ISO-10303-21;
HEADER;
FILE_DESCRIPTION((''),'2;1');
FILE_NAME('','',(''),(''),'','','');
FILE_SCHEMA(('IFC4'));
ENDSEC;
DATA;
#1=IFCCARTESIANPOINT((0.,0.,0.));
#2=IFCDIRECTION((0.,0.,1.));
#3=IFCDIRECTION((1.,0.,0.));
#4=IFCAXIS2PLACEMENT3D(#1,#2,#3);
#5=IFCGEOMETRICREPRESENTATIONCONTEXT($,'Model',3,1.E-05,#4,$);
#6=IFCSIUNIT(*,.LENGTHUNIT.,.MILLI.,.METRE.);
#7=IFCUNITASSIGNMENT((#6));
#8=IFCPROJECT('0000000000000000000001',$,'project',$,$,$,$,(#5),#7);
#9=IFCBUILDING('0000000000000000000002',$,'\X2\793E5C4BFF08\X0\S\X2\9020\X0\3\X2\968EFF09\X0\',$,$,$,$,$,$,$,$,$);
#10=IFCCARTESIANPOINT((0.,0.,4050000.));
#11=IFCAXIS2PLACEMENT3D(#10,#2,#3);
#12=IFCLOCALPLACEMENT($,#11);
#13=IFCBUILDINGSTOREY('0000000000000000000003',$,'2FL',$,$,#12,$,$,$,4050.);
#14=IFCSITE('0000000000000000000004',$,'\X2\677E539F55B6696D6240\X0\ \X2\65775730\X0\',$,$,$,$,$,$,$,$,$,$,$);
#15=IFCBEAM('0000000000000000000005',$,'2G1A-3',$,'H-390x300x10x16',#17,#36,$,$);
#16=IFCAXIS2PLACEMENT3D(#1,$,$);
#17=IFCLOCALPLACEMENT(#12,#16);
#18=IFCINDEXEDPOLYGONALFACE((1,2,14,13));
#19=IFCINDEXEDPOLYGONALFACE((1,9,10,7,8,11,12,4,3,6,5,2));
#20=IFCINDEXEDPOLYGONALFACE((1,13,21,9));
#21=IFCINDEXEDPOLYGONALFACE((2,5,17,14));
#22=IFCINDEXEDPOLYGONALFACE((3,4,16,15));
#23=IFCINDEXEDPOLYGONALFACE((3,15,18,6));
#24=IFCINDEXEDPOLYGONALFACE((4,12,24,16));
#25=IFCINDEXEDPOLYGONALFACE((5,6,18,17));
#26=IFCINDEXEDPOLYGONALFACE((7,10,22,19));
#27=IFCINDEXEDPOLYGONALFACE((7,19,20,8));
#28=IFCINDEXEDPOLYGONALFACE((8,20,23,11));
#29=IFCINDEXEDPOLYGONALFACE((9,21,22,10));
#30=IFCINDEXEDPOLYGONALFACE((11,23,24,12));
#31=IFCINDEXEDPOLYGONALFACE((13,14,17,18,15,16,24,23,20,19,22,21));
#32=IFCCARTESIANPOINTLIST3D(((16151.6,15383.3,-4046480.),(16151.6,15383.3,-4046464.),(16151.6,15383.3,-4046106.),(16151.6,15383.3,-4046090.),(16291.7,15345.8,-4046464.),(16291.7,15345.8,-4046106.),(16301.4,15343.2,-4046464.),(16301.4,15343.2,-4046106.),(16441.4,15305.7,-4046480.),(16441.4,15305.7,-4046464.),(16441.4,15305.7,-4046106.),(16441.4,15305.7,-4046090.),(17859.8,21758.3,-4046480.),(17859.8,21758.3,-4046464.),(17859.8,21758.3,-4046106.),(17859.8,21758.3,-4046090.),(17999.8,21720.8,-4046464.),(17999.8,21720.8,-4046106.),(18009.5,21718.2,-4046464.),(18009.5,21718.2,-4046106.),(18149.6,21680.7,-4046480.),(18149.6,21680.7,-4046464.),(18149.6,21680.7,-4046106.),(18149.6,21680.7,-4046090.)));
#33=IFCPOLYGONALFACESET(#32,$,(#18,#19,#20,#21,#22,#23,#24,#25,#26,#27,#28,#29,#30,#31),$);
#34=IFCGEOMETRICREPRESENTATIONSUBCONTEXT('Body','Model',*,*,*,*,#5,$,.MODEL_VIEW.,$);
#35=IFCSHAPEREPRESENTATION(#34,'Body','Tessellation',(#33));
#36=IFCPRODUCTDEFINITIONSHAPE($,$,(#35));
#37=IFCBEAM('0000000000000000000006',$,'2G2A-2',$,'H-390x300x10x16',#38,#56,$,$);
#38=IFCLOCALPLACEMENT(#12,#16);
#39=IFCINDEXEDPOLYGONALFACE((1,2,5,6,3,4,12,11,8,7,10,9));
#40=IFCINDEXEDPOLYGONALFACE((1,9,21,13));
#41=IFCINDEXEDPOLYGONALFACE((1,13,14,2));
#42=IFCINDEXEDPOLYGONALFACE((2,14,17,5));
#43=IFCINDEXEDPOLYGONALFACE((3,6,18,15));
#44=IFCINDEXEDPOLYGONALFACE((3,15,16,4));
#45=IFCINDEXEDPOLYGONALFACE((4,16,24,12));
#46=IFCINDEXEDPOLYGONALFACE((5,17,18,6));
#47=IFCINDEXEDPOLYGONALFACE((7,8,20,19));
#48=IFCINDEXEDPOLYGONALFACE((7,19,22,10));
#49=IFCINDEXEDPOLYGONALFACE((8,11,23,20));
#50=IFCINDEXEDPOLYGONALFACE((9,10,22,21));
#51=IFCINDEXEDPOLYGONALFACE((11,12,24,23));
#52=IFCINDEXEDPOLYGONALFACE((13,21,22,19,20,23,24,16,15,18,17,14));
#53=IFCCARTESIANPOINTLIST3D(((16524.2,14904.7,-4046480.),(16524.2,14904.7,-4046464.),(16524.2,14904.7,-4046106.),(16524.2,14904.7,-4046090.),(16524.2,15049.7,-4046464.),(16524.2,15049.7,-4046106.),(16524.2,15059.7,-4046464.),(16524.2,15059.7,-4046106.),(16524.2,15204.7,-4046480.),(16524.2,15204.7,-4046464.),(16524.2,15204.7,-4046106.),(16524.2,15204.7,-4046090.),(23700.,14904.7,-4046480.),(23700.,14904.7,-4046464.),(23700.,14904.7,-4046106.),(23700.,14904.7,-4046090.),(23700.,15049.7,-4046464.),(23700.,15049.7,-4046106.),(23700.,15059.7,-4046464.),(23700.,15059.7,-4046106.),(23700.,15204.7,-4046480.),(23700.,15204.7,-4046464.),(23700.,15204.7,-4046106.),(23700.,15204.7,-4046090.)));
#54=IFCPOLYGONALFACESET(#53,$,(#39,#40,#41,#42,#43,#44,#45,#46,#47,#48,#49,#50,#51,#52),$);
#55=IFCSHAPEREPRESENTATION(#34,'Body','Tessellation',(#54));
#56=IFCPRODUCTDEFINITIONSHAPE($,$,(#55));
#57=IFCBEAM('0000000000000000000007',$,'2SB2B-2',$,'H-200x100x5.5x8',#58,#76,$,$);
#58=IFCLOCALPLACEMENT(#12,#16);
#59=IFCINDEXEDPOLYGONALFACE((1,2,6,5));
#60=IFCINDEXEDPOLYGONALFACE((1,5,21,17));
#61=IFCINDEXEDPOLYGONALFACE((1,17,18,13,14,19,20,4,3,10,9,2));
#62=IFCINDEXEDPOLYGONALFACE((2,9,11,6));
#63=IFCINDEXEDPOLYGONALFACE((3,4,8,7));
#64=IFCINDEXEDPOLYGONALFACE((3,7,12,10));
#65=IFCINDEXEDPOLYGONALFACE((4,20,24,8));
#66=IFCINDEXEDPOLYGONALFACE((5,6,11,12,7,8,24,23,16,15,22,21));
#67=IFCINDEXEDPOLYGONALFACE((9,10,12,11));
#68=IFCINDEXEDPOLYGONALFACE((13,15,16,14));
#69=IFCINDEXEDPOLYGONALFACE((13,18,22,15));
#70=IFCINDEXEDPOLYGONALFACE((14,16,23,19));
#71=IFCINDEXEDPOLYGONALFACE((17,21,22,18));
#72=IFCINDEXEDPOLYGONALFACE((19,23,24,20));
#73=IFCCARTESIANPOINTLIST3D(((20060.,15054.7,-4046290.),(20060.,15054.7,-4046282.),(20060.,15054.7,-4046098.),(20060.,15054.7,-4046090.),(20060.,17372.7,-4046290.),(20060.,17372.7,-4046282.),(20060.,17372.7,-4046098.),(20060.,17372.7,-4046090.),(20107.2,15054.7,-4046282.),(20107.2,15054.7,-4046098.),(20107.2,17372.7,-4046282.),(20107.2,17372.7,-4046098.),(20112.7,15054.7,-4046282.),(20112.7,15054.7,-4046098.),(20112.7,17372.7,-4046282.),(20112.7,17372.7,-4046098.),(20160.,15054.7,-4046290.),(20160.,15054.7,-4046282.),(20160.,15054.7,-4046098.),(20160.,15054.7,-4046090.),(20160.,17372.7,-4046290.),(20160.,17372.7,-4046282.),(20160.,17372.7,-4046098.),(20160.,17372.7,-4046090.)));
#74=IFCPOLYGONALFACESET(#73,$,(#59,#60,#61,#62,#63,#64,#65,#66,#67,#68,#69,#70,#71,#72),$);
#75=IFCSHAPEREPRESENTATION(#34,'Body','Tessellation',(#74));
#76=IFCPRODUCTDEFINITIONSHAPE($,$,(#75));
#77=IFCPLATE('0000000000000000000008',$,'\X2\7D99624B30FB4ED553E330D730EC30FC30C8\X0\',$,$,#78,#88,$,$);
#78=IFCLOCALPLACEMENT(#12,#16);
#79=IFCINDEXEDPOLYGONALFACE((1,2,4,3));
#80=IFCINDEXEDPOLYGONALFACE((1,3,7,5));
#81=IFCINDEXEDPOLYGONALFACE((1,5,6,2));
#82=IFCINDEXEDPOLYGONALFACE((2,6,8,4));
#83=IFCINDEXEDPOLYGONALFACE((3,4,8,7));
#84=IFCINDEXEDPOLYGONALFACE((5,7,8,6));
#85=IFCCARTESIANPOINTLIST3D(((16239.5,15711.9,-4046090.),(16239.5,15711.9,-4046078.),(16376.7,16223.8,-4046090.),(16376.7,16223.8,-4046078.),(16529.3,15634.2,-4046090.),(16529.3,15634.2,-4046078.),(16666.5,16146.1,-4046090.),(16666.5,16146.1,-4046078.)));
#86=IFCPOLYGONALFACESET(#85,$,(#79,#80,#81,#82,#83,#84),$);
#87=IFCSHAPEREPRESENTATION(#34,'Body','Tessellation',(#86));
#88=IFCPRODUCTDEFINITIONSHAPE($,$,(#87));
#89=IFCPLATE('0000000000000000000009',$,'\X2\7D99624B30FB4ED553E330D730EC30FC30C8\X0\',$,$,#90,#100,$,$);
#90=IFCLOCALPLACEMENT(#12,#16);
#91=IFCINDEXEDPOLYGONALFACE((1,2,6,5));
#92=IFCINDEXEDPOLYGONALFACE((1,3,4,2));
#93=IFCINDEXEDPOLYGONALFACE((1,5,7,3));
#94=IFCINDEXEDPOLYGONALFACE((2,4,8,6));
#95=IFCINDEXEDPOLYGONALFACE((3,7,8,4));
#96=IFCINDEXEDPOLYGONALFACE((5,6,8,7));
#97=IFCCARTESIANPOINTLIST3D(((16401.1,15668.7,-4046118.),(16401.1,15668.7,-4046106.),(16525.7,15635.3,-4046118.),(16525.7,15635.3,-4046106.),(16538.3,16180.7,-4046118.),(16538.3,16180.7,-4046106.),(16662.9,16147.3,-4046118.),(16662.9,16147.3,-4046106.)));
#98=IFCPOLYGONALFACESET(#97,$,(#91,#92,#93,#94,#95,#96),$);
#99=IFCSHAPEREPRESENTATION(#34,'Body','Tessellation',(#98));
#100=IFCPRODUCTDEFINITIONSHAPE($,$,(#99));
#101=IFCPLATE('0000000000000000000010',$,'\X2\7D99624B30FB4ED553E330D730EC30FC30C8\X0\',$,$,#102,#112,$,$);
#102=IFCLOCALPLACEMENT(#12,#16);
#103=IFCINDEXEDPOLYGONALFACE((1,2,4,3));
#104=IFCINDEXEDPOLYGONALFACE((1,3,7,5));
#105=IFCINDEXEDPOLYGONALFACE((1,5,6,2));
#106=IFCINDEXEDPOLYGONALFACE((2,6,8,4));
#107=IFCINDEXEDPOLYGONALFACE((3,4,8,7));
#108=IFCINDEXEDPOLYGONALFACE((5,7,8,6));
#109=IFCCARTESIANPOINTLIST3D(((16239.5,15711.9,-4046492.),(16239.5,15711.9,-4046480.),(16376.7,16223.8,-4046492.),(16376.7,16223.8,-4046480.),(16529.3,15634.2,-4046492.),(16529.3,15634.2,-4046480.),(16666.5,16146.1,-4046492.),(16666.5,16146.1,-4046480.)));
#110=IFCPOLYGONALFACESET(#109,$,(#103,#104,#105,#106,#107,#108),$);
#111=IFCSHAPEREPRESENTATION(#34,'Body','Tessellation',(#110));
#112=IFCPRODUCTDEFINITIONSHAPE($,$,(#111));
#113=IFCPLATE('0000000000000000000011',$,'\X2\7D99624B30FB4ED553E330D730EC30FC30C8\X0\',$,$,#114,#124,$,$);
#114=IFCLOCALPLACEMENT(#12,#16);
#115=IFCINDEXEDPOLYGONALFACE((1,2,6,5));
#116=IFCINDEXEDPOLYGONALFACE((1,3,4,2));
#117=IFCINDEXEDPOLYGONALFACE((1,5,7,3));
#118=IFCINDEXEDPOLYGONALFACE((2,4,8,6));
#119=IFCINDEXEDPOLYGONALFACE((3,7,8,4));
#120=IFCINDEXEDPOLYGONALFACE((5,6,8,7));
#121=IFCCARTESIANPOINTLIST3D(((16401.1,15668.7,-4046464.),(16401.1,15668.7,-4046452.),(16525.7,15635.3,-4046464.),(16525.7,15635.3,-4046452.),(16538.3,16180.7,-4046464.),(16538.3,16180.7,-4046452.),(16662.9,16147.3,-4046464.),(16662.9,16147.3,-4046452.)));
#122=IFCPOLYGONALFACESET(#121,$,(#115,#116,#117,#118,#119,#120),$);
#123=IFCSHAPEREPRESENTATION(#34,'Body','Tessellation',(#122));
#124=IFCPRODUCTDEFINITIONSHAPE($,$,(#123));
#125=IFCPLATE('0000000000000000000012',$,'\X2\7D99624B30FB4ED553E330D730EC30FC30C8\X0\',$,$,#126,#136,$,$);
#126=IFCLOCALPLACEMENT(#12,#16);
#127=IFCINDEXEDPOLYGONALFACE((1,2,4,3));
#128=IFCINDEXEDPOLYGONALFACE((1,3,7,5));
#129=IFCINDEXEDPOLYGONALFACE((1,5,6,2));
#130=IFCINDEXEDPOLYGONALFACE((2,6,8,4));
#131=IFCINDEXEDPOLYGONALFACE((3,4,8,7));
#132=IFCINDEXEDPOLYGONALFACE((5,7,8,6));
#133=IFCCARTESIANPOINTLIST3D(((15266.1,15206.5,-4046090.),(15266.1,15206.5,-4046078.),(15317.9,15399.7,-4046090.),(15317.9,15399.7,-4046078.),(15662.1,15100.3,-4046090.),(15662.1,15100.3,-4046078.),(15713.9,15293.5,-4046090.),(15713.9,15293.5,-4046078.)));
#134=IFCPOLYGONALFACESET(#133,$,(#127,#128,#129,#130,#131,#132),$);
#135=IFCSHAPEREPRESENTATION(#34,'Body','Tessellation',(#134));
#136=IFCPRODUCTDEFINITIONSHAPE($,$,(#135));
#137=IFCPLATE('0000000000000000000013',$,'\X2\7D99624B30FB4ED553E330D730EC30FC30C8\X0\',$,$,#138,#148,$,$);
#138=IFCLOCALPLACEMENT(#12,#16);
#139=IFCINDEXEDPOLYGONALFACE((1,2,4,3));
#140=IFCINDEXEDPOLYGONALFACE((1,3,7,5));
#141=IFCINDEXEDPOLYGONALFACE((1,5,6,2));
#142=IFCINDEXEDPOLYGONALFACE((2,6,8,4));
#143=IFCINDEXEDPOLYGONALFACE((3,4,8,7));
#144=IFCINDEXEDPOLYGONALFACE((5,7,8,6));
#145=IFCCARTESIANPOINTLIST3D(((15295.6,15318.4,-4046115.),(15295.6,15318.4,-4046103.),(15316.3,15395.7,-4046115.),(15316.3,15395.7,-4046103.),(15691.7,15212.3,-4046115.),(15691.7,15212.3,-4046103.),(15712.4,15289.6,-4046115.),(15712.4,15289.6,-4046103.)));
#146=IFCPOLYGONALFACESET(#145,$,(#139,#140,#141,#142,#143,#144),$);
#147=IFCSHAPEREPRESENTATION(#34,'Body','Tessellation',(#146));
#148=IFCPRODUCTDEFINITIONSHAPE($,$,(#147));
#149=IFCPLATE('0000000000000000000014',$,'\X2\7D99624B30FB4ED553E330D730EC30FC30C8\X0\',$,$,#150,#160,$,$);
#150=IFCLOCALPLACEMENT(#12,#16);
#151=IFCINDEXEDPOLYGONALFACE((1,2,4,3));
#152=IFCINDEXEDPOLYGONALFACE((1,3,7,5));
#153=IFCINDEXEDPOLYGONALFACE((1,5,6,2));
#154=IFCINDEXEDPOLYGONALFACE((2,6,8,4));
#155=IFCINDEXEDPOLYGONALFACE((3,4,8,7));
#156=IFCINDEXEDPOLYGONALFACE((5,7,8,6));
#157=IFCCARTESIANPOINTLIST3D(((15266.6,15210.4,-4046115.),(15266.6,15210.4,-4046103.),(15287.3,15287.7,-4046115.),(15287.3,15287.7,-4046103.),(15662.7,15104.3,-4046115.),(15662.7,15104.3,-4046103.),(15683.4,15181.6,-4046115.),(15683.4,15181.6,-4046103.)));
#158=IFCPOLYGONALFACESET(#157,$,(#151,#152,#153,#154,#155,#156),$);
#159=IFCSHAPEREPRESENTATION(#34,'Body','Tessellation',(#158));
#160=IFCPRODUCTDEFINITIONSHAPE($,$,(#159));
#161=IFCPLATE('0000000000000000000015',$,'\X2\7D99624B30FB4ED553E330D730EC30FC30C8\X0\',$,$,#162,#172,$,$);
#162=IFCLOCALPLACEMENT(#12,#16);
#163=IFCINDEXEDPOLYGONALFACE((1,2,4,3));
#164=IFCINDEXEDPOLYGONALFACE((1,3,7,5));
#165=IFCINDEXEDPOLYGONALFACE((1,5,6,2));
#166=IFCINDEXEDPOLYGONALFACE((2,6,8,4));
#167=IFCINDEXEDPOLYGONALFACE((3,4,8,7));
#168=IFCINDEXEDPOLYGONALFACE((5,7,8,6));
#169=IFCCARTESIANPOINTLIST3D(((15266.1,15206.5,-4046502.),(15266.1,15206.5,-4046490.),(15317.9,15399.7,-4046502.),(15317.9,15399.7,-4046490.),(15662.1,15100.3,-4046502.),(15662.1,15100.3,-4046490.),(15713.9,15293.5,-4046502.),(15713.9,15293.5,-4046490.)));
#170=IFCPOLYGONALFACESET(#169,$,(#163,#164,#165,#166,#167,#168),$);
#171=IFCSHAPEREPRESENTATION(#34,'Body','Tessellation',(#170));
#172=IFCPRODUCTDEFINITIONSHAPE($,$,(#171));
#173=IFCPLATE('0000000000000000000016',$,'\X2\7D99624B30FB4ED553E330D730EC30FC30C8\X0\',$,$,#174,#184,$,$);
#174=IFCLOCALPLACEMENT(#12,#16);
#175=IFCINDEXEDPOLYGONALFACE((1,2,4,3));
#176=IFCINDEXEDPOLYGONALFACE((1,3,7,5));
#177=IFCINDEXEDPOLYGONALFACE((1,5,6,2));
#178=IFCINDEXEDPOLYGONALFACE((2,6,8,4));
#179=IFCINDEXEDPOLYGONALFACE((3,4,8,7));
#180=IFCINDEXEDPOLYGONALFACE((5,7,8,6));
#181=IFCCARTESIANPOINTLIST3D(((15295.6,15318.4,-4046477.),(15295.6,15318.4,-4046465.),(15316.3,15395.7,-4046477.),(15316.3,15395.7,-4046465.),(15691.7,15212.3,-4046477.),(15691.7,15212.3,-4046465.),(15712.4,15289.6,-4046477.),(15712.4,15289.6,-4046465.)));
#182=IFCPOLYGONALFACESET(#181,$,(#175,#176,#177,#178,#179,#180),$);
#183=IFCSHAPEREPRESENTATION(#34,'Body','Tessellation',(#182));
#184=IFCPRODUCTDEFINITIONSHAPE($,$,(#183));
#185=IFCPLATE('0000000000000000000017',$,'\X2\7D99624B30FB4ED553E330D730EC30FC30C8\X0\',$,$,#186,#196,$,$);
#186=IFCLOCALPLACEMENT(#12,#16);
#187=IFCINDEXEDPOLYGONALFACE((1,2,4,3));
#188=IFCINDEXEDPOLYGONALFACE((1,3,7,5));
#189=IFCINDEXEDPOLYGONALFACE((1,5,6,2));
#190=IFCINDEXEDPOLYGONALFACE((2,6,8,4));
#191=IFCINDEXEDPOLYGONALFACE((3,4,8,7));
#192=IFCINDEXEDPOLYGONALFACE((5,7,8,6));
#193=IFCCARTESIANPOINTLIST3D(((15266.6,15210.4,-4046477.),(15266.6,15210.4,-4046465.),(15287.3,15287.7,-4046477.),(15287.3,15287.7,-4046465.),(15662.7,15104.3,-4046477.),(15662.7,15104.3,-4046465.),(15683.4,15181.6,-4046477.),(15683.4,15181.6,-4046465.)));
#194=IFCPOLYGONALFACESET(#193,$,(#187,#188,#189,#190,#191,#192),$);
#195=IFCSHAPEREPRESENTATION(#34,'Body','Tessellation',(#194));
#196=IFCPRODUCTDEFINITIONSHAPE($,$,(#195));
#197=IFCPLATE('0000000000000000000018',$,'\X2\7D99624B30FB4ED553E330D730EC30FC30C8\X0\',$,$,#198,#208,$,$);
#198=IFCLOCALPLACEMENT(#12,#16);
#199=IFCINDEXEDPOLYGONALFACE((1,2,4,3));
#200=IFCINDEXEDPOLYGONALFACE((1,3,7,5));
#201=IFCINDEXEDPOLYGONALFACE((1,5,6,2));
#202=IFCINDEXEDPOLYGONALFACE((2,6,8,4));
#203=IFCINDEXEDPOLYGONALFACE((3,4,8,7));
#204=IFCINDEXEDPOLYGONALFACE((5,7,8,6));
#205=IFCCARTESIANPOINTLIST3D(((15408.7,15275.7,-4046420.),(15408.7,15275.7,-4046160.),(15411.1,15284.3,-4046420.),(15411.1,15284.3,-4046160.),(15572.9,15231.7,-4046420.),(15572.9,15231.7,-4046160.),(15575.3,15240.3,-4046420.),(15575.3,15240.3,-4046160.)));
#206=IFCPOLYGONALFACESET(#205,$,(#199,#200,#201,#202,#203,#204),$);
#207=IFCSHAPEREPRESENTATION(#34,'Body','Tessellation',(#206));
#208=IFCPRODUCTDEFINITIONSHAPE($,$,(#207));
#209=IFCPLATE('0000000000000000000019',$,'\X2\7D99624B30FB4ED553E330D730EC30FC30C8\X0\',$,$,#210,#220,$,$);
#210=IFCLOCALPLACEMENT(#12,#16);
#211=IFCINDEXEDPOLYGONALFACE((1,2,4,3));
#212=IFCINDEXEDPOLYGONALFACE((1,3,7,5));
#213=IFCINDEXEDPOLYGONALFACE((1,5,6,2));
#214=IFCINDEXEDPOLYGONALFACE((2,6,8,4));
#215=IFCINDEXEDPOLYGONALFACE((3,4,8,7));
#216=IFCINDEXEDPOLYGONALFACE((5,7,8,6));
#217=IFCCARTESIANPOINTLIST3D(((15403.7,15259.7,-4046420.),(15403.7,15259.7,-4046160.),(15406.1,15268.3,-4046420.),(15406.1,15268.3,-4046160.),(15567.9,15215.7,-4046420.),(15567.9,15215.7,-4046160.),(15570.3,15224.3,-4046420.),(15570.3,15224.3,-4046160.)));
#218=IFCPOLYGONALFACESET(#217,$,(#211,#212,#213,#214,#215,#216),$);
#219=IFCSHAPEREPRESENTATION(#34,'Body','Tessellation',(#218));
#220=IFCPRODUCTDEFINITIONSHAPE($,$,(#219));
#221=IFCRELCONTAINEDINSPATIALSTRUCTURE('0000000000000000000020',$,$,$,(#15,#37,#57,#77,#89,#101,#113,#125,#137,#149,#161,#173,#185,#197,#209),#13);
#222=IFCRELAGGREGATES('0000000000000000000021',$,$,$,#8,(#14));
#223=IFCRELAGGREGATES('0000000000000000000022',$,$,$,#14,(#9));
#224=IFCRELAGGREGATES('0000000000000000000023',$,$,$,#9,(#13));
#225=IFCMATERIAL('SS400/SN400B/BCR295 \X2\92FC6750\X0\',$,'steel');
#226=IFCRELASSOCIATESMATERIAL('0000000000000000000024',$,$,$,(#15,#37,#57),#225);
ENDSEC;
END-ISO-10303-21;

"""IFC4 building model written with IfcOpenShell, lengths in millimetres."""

from ifc_helpers import new_model, si_unit, frame, origin, origin_with_axes, place, context, subcontext, project, spatial, rectangle, i_section, extrude, material, element, save


model = new_model("IFC4")

# Units and contexts
model_context = context("Model", 3, precision=1e-05, world=origin_with_axes())
body_context = subcontext(model_context, "Body", "Model", "MODEL_VIEW")
ifc_project = project(units=[si_unit("LENGTHUNIT", "METRE", prefix="MILLI")], contexts=[model_context])

# Site, building, storey
site = spatial("IfcSite", under=ifc_project, Name="松原営業所 敷地")
building = spatial("IfcBuilding", under=site, Name="社屋（S造3階）")
storey_placement = place(None, frame((0.0, 0.0, 4050000.0), z_axis=(0.0, 0.0, 1.0), x_axis=(1.0, 0.0, 0.0)))
storey = spatial("IfcBuildingStorey", under=building, at=storey_placement, Name="2FL", Elevation=4050.0)

# Beams
ifc_material = material(Name="SS400/SN400B/BCR295 鋼材", Category="steel")
beam_1_placement = place(storey_placement, frame((16296.5, 15344.5, -4046090.0), z_axis=(0.258815, 0.965927, 0.0), x_axis=(-0.965927, 0.258815, 0.0)))
element("IfcBeam", 1, at=beam_1_placement, inside=storey, material=ifc_material, Name="2G1A-3", ObjectType="H-390x300x10x16", context=body_context, shape_type="SweptSolid", body=[
    extrude(i_section(OverallWidth=300.0, OverallDepth=390.0, WebThickness=10.0, FlangeThickness=16.0), frame((0.0, -195.0, 0.0)), (0.0, 0.0, 1.0), 6599.9),
])
beam_2_placement = place(storey_placement, frame((16524.2, 15054.7, -4046090.0), z_axis=(1.0, 0.0, 0.0), x_axis=(0.0, 1.0, 0.0)))
element("IfcBeam", 2, at=beam_2_placement, inside=storey, material=ifc_material, Name="2G2A-2", ObjectType="H-390x300x10x16", context=body_context, shape_type="SweptSolid", body=[
    extrude(i_section(OverallWidth=300.0, OverallDepth=390.0, WebThickness=10.0, FlangeThickness=16.0), frame((0.0, -195.0, 0.0)), (0.0, 0.0, 1.0), 7175.8),
])
beam_3_placement = place(storey_placement, frame((20110.0, 15054.7, -4046090.0), z_axis=(0.0, 1.0, 0.0), x_axis=(-1.0, 0.0, 0.0)))
element("IfcBeam", 3, at=beam_3_placement, inside=storey, material=ifc_material, Name="2SB2B-2", ObjectType="H-200x100x5.5x8", context=body_context, shape_type="SweptSolid", body=[
    extrude(i_section(OverallWidth=100.0, OverallDepth=200.0, WebThickness=5.5, FlangeThickness=8.0), frame((0.0, -100.0, 0.0)), (0.0, 0.0, 1.0), 2318.0),
])

# Plates
plate_1_placement = place(storey_placement, frame((16384.4, 15673.0, -4046084.0), z_axis=(0.258819, 0.965926, 0.0), x_axis=(-0.965926, 0.258819, 0.0)))
element("IfcPlate", 4, at=plate_1_placement, inside=storey, Name="継手・仕口プレート", context=body_context, shape_type="SweptSolid", body=[
    extrude(rectangle(XDim=300.0, YDim=12.0), origin(), (0.0, 0.0, 1.0), 530.0),
])
plate_2_placement = place(storey_placement, frame((16463.4, 15652.0, -4046112.0), z_axis=(0.258819, 0.965926, 0.0), x_axis=(-0.965926, 0.258819, 0.0)))
element("IfcPlate", 5, at=plate_2_placement, inside=storey, Name="継手・仕口プレート", context=body_context, shape_type="SweptSolid", body=[
    extrude(rectangle(XDim=129.0, YDim=12.0), origin(), (0.0, 0.0, 1.0), 530.0),
])
plate_3_placement = place(storey_placement, frame((16384.4, 15673.0, -4046486.0), z_axis=(0.258819, 0.965926, 0.0), x_axis=(-0.965926, 0.258819, 0.0)))
element("IfcPlate", 6, at=plate_3_placement, inside=storey, Name="継手・仕口プレート", context=body_context, shape_type="SweptSolid", body=[
    extrude(rectangle(XDim=300.0, YDim=12.0), origin(), (0.0, 0.0, 1.0), 530.0),
])
plate_4_placement = place(storey_placement, frame((16463.4, 15652.0, -4046458.0), z_axis=(0.258819, 0.965926, 0.0), x_axis=(-0.965926, 0.258819, 0.0)))
element("IfcPlate", 7, at=plate_4_placement, inside=storey, Name="継手・仕口プレート", context=body_context, shape_type="SweptSolid", body=[
    extrude(rectangle(XDim=129.0, YDim=12.0), origin(), (0.0, 0.0, 1.0), 530.0),
])
plate_5_placement = place(storey_placement, frame((15292.0, 15303.1, -4046084.0), z_axis=(0.965926, -0.258819, 0.0), x_axis=(0.258819, 0.965926, 0.0)))
element("IfcPlate", 8, at=plate_5_placement, inside=storey, Name="継手・仕口プレート", context=body_context, shape_type="SweptSolid", body=[
    extrude(rectangle(XDim=200.0, YDim=12.0), origin(), (0.0, 0.0, 1.0), 410.0),
])
for number, where, z_axis, x_axis, name in (
    (9, (15306.0, 15357.1, -4046109.0), (0.965926, -0.258819, 0.0), (0.258819, 0.965926, 0.0), "継手・仕口プレート"),
    (10, (15277.0, 15249.1, -4046109.0), (0.965926, -0.258819, 0.0), (0.258819, 0.965926, 0.0), "継手・仕口プレート"),
):
    element("IfcPlate", number, at=place(storey_placement, frame(where, z_axis=z_axis, x_axis=x_axis)), inside=storey, Name=name, context=body_context, shape_type="SweptSolid", body=[
        extrude(rectangle(XDim=80.0, YDim=12.0), origin(), (0.0, 0.0, 1.0), 410.0),
    ])
plate_6_placement = place(storey_placement, frame((15292.0, 15303.1, -4046496.0), z_axis=(0.965926, -0.258819, 0.0), x_axis=(0.258819, 0.965926, 0.0)))
element("IfcPlate", 11, at=plate_6_placement, inside=storey, Name="継手・仕口プレート", context=body_context, shape_type="SweptSolid", body=[
    extrude(rectangle(XDim=200.0, YDim=12.0), origin(), (0.0, 0.0, 1.0), 410.0),
])
for number, where, z_axis, x_axis, name in (
    (12, (15306.0, 15357.1, -4046471.0), (0.965926, -0.258819, 0.0), (0.258819, 0.965926, 0.0), "継手・仕口プレート"),
    (13, (15277.0, 15249.1, -4046471.0), (0.965926, -0.258819, 0.0), (0.258819, 0.965926, 0.0), "継手・仕口プレート"),
):
    element("IfcPlate", number, at=place(storey_placement, frame(where, z_axis=z_axis, x_axis=x_axis)), inside=storey, Name=name, context=body_context, shape_type="SweptSolid", body=[
        extrude(rectangle(XDim=80.0, YDim=12.0), origin(), (0.0, 0.0, 1.0), 410.0),
    ])
for number, where, z_axis, x_axis, name in (
    (14, (15409.9, 15280.0, -4046290.0), (0.965926, -0.258819, 0.0), (0.258819, 0.965926, 0.0), "継手・仕口プレート"),
    (15, (15404.9, 15264.0, -4046290.0), (0.965926, -0.258819, 0.0), (0.258819, 0.965926, 0.0), "継手・仕口プレート"),
):
    element("IfcPlate", number, at=place(storey_placement, frame(where, z_axis=z_axis, x_axis=x_axis)), inside=storey, Name=name, context=body_context, shape_type="SweptSolid", body=[
        extrude(rectangle(XDim=9.0, YDim=260.0), origin(), (0.0, 0.0, 1.0), 170.0),
    ])

save(model, "model.ifc")
